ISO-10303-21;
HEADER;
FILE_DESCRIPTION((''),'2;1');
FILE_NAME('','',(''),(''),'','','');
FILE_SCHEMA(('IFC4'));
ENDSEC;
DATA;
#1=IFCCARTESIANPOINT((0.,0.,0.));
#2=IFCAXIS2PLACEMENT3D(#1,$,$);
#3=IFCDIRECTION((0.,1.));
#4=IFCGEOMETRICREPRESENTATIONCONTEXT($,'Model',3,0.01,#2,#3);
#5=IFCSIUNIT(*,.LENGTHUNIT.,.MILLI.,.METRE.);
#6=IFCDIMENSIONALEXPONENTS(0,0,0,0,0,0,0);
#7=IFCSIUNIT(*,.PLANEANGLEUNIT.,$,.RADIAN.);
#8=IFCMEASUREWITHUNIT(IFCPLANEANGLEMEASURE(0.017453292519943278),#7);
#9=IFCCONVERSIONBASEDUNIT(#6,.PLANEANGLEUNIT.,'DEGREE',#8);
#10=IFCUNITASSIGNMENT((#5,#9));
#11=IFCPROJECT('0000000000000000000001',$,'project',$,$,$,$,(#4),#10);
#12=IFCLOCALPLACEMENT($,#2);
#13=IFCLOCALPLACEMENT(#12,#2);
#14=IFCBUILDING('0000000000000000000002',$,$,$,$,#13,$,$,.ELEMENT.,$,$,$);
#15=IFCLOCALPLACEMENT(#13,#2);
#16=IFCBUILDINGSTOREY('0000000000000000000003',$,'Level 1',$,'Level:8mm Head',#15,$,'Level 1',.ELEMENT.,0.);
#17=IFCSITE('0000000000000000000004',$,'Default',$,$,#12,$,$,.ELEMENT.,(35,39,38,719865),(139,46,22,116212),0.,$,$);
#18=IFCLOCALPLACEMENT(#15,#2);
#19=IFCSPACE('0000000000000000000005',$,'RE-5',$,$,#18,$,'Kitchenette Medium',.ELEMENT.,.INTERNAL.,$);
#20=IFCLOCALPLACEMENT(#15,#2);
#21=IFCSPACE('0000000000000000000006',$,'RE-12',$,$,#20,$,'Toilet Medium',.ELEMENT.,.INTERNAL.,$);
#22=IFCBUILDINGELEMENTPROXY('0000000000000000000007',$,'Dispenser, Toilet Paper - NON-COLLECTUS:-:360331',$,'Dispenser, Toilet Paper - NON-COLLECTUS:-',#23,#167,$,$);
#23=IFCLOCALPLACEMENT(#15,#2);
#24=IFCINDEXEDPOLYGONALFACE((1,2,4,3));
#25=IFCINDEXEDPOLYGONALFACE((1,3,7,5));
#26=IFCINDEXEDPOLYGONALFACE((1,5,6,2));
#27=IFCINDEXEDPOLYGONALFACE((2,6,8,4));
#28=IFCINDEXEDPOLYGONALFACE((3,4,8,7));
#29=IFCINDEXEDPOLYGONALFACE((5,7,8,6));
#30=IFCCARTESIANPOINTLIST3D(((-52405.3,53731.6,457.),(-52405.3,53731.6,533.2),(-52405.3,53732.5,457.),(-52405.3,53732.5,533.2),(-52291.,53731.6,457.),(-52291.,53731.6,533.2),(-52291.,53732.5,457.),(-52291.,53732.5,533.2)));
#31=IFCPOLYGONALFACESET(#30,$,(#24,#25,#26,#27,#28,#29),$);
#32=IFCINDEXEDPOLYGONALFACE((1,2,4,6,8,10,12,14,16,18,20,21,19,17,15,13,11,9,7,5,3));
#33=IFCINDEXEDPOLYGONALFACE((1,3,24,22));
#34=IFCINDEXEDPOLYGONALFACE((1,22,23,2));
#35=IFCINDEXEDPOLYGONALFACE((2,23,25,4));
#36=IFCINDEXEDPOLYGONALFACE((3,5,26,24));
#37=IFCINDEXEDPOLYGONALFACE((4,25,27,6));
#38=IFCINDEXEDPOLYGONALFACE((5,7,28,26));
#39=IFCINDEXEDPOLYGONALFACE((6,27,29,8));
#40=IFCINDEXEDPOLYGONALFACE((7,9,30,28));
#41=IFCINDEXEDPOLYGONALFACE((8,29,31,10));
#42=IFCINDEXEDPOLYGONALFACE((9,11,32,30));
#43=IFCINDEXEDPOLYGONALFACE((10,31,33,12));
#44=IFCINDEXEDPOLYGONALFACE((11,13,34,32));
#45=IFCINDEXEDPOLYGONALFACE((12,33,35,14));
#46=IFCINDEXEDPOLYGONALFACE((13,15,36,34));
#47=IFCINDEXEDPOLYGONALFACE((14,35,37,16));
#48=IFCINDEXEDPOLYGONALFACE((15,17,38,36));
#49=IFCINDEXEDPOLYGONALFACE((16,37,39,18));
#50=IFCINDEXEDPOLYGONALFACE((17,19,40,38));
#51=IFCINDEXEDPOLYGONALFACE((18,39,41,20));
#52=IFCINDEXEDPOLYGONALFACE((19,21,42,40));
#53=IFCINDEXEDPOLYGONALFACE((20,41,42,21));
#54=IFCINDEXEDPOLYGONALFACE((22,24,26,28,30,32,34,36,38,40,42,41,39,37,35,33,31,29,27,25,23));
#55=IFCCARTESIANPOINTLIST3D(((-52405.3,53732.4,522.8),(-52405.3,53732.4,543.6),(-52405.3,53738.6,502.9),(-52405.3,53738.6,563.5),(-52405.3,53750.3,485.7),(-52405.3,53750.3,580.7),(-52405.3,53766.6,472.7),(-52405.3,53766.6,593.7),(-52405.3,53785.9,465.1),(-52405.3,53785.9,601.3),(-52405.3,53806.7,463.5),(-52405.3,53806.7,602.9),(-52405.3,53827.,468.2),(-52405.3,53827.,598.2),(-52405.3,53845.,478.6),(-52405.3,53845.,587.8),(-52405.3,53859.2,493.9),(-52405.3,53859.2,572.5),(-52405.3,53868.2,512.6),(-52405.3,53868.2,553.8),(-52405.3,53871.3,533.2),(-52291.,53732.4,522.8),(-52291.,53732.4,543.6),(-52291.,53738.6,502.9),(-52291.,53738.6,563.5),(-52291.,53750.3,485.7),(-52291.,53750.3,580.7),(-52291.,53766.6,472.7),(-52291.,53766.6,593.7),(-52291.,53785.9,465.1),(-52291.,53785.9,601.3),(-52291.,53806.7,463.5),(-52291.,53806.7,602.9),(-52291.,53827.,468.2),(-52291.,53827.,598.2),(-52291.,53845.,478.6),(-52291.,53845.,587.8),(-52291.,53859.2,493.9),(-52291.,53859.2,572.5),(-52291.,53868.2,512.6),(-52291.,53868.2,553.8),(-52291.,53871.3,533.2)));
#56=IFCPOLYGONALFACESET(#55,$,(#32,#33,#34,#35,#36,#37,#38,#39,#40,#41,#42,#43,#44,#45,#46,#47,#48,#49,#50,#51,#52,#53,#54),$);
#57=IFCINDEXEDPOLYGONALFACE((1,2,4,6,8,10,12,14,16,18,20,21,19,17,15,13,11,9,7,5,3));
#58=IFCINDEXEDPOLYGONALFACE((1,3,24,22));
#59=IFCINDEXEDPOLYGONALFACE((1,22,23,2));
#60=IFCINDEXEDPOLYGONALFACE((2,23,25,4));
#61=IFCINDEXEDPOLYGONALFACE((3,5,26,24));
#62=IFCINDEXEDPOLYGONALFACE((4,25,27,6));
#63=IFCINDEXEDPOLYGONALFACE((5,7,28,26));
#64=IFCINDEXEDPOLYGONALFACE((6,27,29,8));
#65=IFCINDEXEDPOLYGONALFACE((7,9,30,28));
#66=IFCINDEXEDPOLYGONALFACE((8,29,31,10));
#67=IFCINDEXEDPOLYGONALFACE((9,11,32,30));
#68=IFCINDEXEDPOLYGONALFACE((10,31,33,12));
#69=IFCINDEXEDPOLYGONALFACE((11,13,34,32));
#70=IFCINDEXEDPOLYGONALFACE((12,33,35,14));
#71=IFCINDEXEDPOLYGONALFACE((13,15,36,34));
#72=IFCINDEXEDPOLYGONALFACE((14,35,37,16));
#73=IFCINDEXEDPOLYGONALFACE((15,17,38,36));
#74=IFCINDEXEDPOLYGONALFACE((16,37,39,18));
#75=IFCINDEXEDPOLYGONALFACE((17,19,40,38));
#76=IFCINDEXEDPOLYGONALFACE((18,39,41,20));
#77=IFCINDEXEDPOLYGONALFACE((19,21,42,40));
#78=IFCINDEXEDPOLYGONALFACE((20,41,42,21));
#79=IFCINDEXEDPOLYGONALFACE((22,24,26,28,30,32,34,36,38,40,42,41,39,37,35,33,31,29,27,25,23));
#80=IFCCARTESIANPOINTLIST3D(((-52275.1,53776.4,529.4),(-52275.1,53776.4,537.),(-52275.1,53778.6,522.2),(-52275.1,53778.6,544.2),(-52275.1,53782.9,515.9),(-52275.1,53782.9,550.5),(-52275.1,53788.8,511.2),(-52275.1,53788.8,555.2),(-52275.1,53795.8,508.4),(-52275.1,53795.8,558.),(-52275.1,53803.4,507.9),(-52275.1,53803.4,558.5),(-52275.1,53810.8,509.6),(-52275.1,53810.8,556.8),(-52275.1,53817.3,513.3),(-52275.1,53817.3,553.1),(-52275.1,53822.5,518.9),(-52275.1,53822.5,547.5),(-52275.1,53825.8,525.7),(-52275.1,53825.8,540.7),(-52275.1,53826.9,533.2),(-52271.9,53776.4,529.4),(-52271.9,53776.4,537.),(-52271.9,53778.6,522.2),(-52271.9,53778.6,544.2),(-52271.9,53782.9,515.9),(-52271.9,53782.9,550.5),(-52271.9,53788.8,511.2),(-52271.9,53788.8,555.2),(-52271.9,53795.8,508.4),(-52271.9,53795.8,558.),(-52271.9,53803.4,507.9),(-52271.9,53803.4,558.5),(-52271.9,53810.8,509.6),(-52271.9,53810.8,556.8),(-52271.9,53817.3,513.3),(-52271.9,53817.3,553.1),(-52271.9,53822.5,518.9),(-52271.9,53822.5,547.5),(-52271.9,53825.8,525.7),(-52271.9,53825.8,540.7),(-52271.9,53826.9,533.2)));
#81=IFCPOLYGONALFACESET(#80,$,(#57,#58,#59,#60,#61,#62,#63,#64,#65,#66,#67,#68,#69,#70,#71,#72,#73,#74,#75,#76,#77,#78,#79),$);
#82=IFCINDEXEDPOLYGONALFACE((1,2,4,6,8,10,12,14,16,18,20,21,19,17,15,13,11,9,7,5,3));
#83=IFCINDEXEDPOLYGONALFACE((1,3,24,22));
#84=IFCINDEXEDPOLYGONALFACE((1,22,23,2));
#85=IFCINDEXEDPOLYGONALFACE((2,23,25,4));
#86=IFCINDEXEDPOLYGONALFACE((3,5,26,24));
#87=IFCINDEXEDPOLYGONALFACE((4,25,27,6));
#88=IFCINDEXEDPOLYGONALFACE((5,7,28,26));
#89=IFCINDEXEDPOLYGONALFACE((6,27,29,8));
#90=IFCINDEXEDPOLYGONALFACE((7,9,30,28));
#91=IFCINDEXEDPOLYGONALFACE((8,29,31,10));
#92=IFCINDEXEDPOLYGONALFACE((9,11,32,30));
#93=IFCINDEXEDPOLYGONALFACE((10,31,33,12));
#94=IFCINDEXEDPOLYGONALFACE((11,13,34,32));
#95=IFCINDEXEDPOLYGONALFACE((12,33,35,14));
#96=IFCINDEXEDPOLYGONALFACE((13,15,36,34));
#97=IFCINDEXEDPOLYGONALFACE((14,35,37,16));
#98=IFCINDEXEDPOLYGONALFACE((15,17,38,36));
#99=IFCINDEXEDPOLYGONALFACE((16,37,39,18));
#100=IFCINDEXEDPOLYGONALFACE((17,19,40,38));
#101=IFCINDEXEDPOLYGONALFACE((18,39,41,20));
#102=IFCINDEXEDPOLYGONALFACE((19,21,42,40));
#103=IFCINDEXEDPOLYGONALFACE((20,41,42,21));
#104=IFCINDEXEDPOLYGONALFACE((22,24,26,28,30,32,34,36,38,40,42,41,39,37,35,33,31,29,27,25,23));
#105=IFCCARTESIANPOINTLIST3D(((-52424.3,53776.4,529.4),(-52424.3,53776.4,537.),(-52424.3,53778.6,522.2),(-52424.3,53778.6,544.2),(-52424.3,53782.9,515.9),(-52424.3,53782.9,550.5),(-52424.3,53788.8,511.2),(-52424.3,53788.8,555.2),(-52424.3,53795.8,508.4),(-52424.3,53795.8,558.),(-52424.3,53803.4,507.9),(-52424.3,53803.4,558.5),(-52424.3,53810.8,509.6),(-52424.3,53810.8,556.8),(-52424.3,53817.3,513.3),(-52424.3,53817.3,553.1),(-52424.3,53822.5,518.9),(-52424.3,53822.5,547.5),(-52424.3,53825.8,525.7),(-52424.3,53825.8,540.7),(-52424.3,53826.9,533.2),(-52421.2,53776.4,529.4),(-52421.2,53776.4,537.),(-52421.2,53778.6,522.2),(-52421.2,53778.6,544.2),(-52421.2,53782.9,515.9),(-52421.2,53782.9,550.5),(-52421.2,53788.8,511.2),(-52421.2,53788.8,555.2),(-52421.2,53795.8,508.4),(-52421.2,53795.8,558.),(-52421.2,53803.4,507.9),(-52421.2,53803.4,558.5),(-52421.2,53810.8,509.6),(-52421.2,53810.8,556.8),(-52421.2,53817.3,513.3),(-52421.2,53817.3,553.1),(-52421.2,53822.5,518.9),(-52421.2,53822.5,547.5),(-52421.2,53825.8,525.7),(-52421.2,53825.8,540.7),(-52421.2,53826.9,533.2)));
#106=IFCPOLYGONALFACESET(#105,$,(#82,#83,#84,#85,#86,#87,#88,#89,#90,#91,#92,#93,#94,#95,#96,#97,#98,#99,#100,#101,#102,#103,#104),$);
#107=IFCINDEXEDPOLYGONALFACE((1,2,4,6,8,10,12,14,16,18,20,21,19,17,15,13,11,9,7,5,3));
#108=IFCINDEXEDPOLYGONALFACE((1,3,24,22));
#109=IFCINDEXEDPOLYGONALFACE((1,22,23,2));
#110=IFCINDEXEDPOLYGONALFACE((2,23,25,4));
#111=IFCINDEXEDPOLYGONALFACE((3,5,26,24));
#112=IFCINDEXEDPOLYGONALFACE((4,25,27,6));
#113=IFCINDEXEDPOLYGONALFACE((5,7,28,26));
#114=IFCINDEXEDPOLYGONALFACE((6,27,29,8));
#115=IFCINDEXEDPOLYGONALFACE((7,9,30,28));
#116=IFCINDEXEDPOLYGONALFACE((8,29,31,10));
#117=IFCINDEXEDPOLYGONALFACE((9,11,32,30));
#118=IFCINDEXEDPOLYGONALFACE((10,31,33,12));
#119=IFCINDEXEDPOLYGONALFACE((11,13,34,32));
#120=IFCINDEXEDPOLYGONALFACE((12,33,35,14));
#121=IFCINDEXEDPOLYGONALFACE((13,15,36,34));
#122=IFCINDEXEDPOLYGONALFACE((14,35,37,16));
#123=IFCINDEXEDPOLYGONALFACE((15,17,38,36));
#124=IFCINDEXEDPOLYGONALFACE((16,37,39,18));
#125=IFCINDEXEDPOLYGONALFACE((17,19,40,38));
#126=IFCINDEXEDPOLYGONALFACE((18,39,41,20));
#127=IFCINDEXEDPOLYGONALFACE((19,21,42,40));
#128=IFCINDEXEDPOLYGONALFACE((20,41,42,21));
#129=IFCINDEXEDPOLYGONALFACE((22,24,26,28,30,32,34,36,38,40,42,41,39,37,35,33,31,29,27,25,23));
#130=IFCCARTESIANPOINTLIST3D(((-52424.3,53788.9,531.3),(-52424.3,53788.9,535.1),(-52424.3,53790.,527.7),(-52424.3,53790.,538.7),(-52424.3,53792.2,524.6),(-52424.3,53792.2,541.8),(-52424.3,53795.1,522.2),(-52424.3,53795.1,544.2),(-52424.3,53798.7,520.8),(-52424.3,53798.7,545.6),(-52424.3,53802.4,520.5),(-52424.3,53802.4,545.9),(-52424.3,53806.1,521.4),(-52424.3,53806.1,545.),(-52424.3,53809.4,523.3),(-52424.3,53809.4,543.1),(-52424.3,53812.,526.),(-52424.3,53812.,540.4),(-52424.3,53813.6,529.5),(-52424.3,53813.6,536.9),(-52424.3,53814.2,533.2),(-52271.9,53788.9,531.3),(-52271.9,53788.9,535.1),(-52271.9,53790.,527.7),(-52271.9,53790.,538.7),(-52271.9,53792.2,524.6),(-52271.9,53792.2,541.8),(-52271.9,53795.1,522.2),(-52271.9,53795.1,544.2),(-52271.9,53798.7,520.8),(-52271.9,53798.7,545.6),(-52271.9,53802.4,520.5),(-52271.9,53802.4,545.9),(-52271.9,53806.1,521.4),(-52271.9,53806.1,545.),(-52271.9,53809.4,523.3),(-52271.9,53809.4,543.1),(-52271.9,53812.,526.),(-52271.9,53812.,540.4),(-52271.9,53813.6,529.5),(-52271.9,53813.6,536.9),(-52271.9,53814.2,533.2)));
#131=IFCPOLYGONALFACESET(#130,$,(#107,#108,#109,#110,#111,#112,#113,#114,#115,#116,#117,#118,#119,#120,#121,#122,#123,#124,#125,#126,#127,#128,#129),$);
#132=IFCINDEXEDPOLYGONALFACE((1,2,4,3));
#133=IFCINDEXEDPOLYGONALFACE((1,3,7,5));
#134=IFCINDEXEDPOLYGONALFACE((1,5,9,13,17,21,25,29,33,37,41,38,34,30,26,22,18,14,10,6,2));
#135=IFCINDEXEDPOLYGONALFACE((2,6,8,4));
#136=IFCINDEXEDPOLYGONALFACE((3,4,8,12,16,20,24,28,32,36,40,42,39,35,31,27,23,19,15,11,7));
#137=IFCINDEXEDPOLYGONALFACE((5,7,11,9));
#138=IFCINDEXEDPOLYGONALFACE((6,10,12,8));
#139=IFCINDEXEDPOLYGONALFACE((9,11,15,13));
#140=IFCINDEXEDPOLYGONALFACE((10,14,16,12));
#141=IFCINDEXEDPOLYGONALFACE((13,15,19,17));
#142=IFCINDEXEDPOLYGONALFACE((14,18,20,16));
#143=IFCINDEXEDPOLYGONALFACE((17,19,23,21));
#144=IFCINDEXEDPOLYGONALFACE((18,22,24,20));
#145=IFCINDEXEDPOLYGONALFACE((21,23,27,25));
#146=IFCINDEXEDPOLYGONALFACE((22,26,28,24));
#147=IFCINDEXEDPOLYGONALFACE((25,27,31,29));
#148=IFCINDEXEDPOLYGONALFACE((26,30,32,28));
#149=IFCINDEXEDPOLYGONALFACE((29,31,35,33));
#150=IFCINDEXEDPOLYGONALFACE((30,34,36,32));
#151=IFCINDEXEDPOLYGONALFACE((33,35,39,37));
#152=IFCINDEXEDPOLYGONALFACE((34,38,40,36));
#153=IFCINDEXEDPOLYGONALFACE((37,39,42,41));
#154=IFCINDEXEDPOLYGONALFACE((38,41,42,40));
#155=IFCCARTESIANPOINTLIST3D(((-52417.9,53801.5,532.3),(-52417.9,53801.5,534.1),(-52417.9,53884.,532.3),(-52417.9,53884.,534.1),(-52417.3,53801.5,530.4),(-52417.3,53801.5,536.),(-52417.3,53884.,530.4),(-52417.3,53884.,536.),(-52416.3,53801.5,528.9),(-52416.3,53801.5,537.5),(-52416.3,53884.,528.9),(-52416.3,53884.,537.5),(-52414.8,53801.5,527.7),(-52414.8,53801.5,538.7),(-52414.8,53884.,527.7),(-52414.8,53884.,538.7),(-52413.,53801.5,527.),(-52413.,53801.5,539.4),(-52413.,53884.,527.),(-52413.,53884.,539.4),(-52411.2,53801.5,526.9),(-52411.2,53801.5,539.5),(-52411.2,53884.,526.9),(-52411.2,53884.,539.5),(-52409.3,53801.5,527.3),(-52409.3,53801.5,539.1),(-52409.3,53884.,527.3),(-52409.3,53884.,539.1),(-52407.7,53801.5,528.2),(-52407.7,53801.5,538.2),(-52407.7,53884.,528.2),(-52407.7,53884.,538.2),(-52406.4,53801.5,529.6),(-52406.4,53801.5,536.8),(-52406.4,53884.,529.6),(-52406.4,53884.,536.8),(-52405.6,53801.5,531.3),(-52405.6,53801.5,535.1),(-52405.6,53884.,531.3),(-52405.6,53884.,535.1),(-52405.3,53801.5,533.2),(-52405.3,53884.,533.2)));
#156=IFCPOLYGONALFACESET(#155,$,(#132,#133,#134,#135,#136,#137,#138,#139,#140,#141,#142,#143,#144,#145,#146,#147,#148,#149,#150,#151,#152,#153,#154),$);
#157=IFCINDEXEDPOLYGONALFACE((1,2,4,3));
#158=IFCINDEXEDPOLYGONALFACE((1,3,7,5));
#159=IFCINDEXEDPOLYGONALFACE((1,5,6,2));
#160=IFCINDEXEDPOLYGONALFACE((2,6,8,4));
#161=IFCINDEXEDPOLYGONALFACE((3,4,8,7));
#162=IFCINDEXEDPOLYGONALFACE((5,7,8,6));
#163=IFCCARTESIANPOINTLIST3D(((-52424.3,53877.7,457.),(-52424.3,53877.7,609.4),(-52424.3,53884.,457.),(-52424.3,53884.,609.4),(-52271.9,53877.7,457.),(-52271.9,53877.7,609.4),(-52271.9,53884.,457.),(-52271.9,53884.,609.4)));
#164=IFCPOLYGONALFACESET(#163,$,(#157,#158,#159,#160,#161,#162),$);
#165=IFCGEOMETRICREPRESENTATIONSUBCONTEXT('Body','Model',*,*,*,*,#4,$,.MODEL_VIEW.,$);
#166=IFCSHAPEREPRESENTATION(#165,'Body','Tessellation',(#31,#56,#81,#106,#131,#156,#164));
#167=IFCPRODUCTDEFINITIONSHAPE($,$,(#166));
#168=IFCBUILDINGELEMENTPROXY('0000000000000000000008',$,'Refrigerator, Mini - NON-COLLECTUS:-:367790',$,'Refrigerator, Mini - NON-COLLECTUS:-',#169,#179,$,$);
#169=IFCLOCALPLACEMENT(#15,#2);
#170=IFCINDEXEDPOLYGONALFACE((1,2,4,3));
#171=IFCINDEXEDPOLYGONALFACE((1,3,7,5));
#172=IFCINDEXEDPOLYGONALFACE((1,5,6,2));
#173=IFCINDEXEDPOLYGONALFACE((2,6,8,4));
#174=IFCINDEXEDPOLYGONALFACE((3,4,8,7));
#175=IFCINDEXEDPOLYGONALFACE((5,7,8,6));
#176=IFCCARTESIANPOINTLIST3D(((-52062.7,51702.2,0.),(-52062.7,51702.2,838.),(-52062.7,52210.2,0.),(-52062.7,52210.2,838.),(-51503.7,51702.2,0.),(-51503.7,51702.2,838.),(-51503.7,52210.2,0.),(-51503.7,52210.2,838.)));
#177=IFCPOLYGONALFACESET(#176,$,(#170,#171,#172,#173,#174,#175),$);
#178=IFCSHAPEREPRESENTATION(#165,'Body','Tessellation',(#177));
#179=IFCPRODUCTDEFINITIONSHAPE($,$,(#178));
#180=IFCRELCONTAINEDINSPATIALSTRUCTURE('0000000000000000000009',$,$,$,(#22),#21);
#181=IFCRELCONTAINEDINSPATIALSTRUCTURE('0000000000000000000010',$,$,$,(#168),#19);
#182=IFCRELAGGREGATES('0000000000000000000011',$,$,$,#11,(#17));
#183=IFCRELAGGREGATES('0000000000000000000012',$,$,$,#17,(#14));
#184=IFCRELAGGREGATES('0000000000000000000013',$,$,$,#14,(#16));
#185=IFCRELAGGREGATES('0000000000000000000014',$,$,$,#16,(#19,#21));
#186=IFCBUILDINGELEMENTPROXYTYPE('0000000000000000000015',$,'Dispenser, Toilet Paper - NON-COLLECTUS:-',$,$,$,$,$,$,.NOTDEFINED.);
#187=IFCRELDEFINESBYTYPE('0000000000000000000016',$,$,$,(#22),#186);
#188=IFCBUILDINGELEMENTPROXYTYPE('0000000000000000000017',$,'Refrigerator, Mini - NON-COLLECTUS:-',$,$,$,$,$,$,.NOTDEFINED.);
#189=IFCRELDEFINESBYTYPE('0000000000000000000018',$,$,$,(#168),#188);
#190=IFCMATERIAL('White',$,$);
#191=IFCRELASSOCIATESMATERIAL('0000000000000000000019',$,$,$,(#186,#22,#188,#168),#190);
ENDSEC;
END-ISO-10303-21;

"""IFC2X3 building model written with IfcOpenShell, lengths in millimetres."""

from ifc_helpers import new_model, entity, si_unit, converted_unit, direction, frame, frame_2d, origin, origin_2d_with_axis, place, context, subcontext, project, spatial, rectangle, circle, extrude, source, transform, mapped, material, type_object, type_shapes, element, save


model = new_model("IFC2X3")

# Units and contexts
model_context = context("Model", 3, precision=0.01, world=origin(), true_north=direction((0.0, 1.0)))
body_context = subcontext(model_context, "Body", "Model", "MODEL_VIEW")
ifc_project = project(units=[si_unit("LENGTHUNIT", "METRE", prefix="MILLI"), converted_unit("PLANEANGLEUNIT", "DEGREE", entity("IfcPlaneAngleMeasure", 0.017453292519943278), si_unit("PLANEANGLEUNIT", "RADIAN"), dimensions=[0, 0, 0, 0, 0, 0, 0])], contexts=[model_context])

# Site, building, storey
site_placement = place(None, origin())
site = spatial("IfcSite", under=ifc_project, at=site_placement, Name="Default", CompositionType="ELEMENT", RefLatitude=(35, 39, 38, 719865), RefLongitude=(139, 46, 22, 116212), RefElevation=0.0)
building_placement = place(site_placement, origin())
building = spatial("IfcBuilding", under=site, at=building_placement, CompositionType="ELEMENT")
storey_placement = place(building_placement, origin())
storey = spatial("IfcBuildingStorey", under=building, at=storey_placement, Name="Level 1", ObjectType="Level:8mm Head", LongName="Level 1", CompositionType="ELEMENT", Elevation=0.0)

# Shared definitions
ifc_material_1 = material(Name="White")

# Shared definitions
space_1_placement = place(storey_placement, origin())
space_1 = spatial("IfcSpace", under=storey, at=space_1_placement, Name="RE-5", LongName="Kitchenette Medium", CompositionType="ELEMENT", InteriorOrExteriorSpace="INTERNAL")

# Shared definitions
space_2_placement = place(storey_placement, origin())
space_2 = spatial("IfcSpace", under=storey, at=space_2_placement, Name="RE-12", LongName="Toilet Medium", CompositionType="ELEMENT", InteriorOrExteriorSpace="INTERNAL")

# Building element proxies
building_element_proxy_type_1 = type_object("IfcBuildingElementProxyType", Name="Dispenser, Toilet Paper - NON-COLLECTUS:-", PredefinedType="NOTDEFINED", material=ifc_material_1)
shared_shape_1 = source(origin(), body_context, "Body", "SweptSolid", [
    extrude(rectangle(XDim=114.3, YDim=0.9, at=origin_2d_with_axis()), frame((0.0, -152.0, 0.0), z_axis=(0.0, 0.0, 1.0), x_axis=(-1.0, 0.0, 0.0)), (0.0, 0.0, 1.0), 76.2),
    extrude(circle(Radius=69.9, at=frame_2d((0.0, 0.0), x_axis=(1.0, 0.0))), frame((-57.2, -82.5, 76.2), z_axis=(1.0, 0.0, 0.0), x_axis=(0.0, 1.0, 0.0)), (0.0, 0.0, 1.0), 114.3),
    extrude(circle(Radius=25.4, at=frame_2d((0.0, 0.0), x_axis=(1.0, 0.0))), frame((73.0, -82.5, 76.2), z_axis=(1.0, 0.0, 0.0), x_axis=(0.0, 1.0, 0.0)), (0.0, 0.0, 1.0), 3.2),
    extrude(circle(Radius=25.4, at=frame_2d((0.0, 0.0), x_axis=(1.0, 0.0))), frame((-76.2, -82.5, 76.2), z_axis=(1.0, 0.0, 0.0), x_axis=(0.0, 1.0, 0.0)), (0.0, 0.0, 1.0), 3.2),
    extrude(circle(Radius=12.7, at=frame_2d((0.0, 0.0), x_axis=(1.0, 0.0))), frame((-76.2, -82.5, 76.2), z_axis=(1.0, 0.0, 0.0), x_axis=(0.0, 1.0, 0.0)), (0.0, 0.0, 1.0), 152.4),
    extrude(circle(Radius=6.4, at=frame_2d((0.0, 0.0), x_axis=(1.0, 0.0))), frame((-63.5, -82.5, 76.2), z_axis=(0.0, 1.0, 0.0), x_axis=(1.0, 0.0, 0.0)), (0.0, 0.0, 1.0), 82.5),
    extrude(rectangle(XDim=6.4, YDim=152.4, at=origin_2d_with_axis()), frame((0.0, -3.2, 0.0), z_axis=(0.0, 0.0, 1.0), x_axis=(0.0, 1.0, 0.0)), (0.0, 0.0, 1.0), 152.4),
])
type_shapes(building_element_proxy_type_1, [shared_shape_1])
proxy_1_placement = place(space_2_placement, frame((-52348.1, 53884.0, 457.0)))
element("IfcBuildingElementProxy", 1, at=proxy_1_placement, inside=space_2, type_object=building_element_proxy_type_1, material=ifc_material_1, Name="Dispenser, Toilet Paper - NON-COLLECTUS:-:360331", ObjectType="Dispenser, Toilet Paper - NON-COLLECTUS:-", context=body_context, shape_type="MappedRepresentation", body=[
    mapped(shared_shape_1, transform((0.0, 0.0, 0.0), scale=1.0)),
])
building_element_proxy_type_2 = type_object("IfcBuildingElementProxyType", Name="Refrigerator, Mini - NON-COLLECTUS:-", PredefinedType="NOTDEFINED", material=ifc_material_1)
shared_shape_2 = source(origin(), body_context, "Body", "SweptSolid", [
    extrude(rectangle(XDim=559.0, YDim=508.0, at=origin_2d_with_axis()), frame((254.0, 279.5, 0.0), z_axis=(0.0, 0.0, 1.0), x_axis=(0.0, 1.0, 0.0)), (0.0, 0.0, 1.0), 838.0),
])
type_shapes(building_element_proxy_type_2, [shared_shape_2])
proxy_2_placement = place(space_1_placement, frame((-52062.7, 52210.2, 0.0), z_axis=(0.0, 0.0, 1.0), x_axis=(0.000011, -1.0, 0.0)))
element("IfcBuildingElementProxy", 2, at=proxy_2_placement, inside=space_1, type_object=building_element_proxy_type_2, material=ifc_material_1, Name="Refrigerator, Mini - NON-COLLECTUS:-:367790", ObjectType="Refrigerator, Mini - NON-COLLECTUS:-", context=body_context, shape_type="MappedRepresentation", body=[
    mapped(shared_shape_2, transform((0.0, 0.0, 0.0), scale=1.0)),
])

save(model, "model.ifc")
